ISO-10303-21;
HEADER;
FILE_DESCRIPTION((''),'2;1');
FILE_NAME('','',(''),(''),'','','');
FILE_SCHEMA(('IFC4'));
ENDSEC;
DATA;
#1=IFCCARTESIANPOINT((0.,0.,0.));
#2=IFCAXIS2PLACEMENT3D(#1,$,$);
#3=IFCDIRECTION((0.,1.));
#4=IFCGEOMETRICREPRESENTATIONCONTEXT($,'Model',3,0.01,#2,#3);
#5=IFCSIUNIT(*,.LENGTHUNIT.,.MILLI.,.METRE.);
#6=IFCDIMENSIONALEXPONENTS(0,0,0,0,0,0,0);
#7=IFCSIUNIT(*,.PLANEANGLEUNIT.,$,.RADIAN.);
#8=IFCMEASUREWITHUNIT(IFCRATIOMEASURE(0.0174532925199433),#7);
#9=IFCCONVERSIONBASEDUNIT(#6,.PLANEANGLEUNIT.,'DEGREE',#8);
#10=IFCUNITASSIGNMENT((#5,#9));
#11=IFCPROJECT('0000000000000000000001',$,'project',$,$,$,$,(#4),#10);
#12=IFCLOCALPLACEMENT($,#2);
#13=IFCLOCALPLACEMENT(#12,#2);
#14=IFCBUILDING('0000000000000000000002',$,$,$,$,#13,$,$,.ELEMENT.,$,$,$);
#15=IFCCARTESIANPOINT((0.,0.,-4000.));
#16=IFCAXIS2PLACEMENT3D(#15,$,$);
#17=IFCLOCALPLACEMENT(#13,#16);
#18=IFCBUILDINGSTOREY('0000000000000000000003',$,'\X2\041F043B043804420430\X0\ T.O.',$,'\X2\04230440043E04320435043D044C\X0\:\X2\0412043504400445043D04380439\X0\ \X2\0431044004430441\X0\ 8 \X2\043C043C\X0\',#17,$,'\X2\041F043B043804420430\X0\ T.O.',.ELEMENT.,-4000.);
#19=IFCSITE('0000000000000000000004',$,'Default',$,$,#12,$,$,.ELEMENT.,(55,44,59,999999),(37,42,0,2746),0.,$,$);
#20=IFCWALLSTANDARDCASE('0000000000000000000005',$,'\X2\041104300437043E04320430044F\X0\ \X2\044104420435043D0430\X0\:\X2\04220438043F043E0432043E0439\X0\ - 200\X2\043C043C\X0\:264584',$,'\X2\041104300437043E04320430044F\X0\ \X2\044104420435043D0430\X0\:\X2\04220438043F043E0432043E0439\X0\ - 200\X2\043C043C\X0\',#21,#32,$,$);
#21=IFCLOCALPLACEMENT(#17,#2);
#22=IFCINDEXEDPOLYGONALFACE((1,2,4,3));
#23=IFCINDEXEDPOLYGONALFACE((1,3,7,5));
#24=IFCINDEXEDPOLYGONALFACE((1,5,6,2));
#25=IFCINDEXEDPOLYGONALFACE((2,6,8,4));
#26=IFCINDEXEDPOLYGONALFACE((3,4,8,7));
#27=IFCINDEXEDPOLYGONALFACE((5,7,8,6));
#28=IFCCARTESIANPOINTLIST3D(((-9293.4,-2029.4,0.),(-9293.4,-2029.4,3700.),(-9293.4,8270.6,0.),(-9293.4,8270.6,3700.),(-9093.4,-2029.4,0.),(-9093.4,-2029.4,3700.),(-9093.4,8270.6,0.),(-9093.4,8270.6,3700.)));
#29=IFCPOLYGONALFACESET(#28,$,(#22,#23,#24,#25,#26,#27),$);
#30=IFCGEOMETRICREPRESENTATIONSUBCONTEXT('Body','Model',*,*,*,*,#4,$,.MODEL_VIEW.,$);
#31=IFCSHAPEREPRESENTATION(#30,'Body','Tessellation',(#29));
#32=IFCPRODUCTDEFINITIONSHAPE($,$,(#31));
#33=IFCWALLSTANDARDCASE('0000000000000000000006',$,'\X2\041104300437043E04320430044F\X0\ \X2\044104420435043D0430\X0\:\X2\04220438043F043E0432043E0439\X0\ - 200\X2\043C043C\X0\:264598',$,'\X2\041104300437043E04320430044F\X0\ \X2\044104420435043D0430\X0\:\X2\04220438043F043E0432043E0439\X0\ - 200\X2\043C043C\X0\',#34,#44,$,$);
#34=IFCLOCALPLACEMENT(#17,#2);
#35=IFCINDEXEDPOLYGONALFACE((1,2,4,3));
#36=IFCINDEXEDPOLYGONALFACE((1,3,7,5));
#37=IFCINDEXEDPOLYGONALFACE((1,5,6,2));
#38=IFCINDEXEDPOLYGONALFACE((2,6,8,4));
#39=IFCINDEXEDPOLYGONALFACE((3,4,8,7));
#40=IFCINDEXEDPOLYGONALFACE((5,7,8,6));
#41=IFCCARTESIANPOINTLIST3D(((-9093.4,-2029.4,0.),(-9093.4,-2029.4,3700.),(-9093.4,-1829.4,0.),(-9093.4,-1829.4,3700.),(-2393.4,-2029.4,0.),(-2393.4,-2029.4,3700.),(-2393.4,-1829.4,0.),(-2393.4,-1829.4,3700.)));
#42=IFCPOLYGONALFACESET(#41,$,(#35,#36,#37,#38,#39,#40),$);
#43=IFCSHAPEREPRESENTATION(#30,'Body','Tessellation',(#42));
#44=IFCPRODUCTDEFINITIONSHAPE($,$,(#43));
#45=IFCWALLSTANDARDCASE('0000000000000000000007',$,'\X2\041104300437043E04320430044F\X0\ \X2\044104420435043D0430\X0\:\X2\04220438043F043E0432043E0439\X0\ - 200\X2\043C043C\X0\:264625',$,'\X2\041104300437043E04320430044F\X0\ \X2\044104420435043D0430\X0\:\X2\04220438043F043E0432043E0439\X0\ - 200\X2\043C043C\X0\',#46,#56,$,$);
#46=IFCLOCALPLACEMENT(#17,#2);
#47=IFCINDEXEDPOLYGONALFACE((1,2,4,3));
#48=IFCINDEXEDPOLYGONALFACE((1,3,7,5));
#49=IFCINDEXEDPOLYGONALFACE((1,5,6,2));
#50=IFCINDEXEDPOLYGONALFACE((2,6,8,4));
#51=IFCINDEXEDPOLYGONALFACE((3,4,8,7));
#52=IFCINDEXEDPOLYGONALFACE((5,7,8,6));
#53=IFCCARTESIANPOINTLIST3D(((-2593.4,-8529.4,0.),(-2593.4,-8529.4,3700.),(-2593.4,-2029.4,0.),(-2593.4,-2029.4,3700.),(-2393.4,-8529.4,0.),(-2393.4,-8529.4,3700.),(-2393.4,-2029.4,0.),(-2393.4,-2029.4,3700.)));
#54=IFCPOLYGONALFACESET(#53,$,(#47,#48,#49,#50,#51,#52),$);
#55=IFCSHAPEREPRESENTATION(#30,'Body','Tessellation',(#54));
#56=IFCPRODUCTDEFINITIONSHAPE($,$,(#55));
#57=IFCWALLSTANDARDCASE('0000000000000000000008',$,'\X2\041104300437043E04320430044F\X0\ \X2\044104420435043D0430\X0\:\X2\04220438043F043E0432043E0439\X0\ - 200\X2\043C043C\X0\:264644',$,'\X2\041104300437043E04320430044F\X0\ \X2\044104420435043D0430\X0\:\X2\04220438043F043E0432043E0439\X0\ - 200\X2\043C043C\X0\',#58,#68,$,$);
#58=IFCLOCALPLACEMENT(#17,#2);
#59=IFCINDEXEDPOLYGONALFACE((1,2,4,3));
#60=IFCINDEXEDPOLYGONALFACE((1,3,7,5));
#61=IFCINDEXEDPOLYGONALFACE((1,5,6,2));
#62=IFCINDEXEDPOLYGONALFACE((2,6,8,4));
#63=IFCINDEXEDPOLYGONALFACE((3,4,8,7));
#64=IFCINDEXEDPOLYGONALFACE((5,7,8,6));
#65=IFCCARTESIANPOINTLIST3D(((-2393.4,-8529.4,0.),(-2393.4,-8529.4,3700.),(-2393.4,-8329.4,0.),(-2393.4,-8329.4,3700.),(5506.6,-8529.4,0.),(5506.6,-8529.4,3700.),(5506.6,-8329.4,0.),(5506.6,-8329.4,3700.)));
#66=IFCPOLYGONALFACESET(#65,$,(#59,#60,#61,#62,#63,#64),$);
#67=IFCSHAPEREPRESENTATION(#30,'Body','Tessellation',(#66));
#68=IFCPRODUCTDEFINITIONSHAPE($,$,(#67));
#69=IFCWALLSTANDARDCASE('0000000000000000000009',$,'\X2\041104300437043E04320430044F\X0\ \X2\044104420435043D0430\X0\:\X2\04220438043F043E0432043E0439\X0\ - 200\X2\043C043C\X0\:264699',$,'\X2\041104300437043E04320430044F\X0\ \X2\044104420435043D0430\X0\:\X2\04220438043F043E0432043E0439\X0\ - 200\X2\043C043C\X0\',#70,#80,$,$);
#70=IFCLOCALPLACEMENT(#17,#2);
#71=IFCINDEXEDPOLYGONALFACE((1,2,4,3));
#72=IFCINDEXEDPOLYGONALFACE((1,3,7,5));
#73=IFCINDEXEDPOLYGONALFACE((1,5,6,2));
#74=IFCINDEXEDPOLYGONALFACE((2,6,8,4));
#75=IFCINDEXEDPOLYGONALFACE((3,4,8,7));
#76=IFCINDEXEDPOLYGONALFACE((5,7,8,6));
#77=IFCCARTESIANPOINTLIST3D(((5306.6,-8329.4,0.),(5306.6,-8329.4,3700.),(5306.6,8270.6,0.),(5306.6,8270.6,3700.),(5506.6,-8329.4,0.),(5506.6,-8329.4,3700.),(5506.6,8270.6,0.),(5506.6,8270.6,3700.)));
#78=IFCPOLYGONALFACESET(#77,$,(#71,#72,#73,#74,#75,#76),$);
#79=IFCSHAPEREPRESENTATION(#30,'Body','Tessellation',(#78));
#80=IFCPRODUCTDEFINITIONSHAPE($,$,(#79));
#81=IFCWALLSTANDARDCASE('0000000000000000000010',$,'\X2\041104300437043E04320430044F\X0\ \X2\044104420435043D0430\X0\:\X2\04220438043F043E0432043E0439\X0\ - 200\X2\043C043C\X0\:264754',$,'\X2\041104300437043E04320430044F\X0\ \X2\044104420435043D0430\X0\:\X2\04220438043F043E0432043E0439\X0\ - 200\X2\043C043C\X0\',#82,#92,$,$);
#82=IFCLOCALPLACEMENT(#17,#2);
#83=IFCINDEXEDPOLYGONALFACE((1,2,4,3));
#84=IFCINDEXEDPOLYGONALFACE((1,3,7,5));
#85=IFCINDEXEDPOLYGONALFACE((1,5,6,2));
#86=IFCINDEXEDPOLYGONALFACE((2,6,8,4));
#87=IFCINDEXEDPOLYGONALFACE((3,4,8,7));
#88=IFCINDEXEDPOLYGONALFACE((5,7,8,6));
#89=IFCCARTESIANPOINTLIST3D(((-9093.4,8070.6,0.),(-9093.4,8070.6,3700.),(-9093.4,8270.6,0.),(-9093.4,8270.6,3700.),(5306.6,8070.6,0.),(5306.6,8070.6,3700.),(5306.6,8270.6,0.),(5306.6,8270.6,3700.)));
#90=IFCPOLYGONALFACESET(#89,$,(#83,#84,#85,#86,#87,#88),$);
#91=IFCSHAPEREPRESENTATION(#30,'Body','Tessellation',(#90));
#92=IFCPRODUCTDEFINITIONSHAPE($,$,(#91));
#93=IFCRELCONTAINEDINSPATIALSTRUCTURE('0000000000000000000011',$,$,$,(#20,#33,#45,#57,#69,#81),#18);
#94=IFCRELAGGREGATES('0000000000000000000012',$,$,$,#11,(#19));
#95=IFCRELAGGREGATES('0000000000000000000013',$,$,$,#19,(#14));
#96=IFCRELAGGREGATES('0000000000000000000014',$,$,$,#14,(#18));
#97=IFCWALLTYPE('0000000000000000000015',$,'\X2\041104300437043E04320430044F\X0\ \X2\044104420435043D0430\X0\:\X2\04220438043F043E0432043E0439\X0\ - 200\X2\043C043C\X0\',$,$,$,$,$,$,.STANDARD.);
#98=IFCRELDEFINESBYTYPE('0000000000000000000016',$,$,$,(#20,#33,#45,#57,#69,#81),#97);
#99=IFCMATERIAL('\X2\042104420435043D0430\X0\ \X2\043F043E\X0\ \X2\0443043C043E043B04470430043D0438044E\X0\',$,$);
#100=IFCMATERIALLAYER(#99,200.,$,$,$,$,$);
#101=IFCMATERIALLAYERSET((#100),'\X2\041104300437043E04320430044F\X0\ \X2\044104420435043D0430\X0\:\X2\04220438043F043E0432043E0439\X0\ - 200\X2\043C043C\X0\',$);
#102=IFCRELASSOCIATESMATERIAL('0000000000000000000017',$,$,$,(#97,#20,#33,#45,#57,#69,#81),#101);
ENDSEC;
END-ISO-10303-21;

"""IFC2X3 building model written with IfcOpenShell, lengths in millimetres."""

from ifc_helpers import new_model, entity, si_unit, converted_unit, direction, frame, frame_2d, origin, place, context, subcontext, project, spatial, rectangle, extrude, clip, halfspace, material, layer, layer_set, layer_usage, type_object, element, save


model = new_model("IFC2X3")

# Units and contexts
model_context = context("Model", 3, precision=0.01, world=origin(), true_north=direction((0.0, 1.0)))
body_context = subcontext(model_context, "Body", "Model", "MODEL_VIEW")
ifc_project = project(units=[si_unit("LENGTHUNIT", "METRE", prefix="MILLI"), converted_unit("PLANEANGLEUNIT", "DEGREE", entity("IfcRatioMeasure", 0.0174532925199433), si_unit("PLANEANGLEUNIT", "RADIAN"), dimensions=[0, 0, 0, 0, 0, 0, 0])], contexts=[model_context])

# Site, building, storey
site_placement = place(None, origin())
site = spatial("IfcSite", under=ifc_project, at=site_placement, Name="Default", CompositionType="ELEMENT", RefLatitude=(55, 44, 59, 999999), RefLongitude=(37, 42, 0, 2746), RefElevation=0.0)
building_placement = place(site_placement, origin())
building = spatial("IfcBuilding", under=site, at=building_placement, CompositionType="ELEMENT")
storey_placement = place(building_placement, frame((0.0, 0.0, -4000.0)))
storey = spatial("IfcBuildingStorey", under=building, at=storey_placement, Name="Плита T.O.", ObjectType="Уровень:Верхний брус 8 мм", LongName="Плита T.O.", CompositionType="ELEMENT", Elevation=-4000.0)

# Walls
ifc_material = material(Name="Стена по умолчанию")
ifc_layer = layer(ifc_material, 200.0)
ifc_layer_set = layer_set([ifc_layer], Name="Базовая стена:Типовой - 200мм")
ifc_layer_usage_1 = layer_usage(ifc_layer_set, "AXIS2", "NEGATIVE", 100.0)
wall_type = type_object("IfcWallType", Name="Базовая стена:Типовой - 200мм", PredefinedType="STANDARD", material=ifc_layer_set)
wall_1_placement = place(storey_placement, frame((-9193.4, 8270.6, 0.0), z_axis=(0.0, 0.0, 1.0), x_axis=(0.0, -1.0, 0.0)))
element("IfcWallStandardCase", 1, at=wall_1_placement, inside=storey, type_object=wall_type, material=ifc_layer_usage_1, Name="Базовая стена:Типовой - 200мм:264584", ObjectType="Базовая стена:Типовой - 200мм", context=body_context, shape_type="Clipping", body=[
    clip(extrude(rectangle(XDim=10300.0, YDim=200.0, at=frame_2d((5150.0, 0.0), x_axis=(-1.0, 0.0))), origin(), (0.0, 0.0, 1.0), 3700.0), halfspace(frame((0.0, 0.0, -600.0)), True)),
])
ifc_layer_usage_2 = layer_usage(ifc_layer_set, "AXIS2", "NEGATIVE", 100.0)
wall_2_placement = place(storey_placement, frame((-9093.4, -1929.4, 0.0)))
element("IfcWallStandardCase", 2, at=wall_2_placement, inside=storey, type_object=wall_type, material=ifc_layer_usage_2, Name="Базовая стена:Типовой - 200мм:264598", ObjectType="Базовая стена:Типовой - 200мм", context=body_context, shape_type="Clipping", body=[
    clip(extrude(rectangle(XDim=6700.0, YDim=200.0, at=frame_2d((3350.0, 0.0), x_axis=(-1.0, 0.0))), origin(), (0.0, 0.0, 1.0), 3700.0), halfspace(frame((0.0, 0.0, -600.0)), True)),
])
ifc_layer_usage_3 = layer_usage(ifc_layer_set, "AXIS2", "NEGATIVE", 100.0)
wall_3_placement = place(storey_placement, frame((-2493.4, -2029.4, 0.0), z_axis=(0.0, 0.0, 1.0), x_axis=(0.0, -1.0, 0.0)))
element("IfcWallStandardCase", 3, at=wall_3_placement, inside=storey, type_object=wall_type, material=ifc_layer_usage_3, Name="Базовая стена:Типовой - 200мм:264625", ObjectType="Базовая стена:Типовой - 200мм", context=body_context, shape_type="Clipping", body=[
    clip(extrude(rectangle(XDim=6500.0, YDim=200.0, at=frame_2d((3250.0, 0.0), x_axis=(-1.0, 0.0))), origin(), (0.0, 0.0, 1.0), 3700.0), halfspace(frame((0.0, 0.0, -600.0)), True)),
])
ifc_layer_usage_4 = layer_usage(ifc_layer_set, "AXIS2", "NEGATIVE", 100.0)
wall_4_placement = place(storey_placement, frame((-2393.4, -8429.4, 0.0)))
element("IfcWallStandardCase", 4, at=wall_4_placement, inside=storey, type_object=wall_type, material=ifc_layer_usage_4, Name="Базовая стена:Типовой - 200мм:264644", ObjectType="Базовая стена:Типовой - 200мм", context=body_context, shape_type="Clipping", body=[
    clip(extrude(rectangle(XDim=7900.0, YDim=200.0, at=frame_2d((3950.0, 0.0), x_axis=(-1.0, 0.0))), origin(), (0.0, 0.0, 1.0), 3700.0), halfspace(frame((0.0, 0.0, -600.0)), True)),
])
ifc_layer_usage_5 = layer_usage(ifc_layer_set, "AXIS2", "NEGATIVE", 100.0)
wall_5_placement = place(storey_placement, frame((5406.6, -8329.4, 0.0), z_axis=(0.0, 0.0, 1.0), x_axis=(0.0, 1.0, 0.0)))
element("IfcWallStandardCase", 5, at=wall_5_placement, inside=storey, type_object=wall_type, material=ifc_layer_usage_5, Name="Базовая стена:Типовой - 200мм:264699", ObjectType="Базовая стена:Типовой - 200мм", context=body_context, shape_type="Clipping", body=[
    clip(extrude(rectangle(XDim=16600.0, YDim=200.0, at=frame_2d((8300.0, 0.0), x_axis=(-1.0, 0.0))), origin(), (0.0, 0.0, 1.0), 3700.0), halfspace(frame((0.0, 0.0, -600.0)), True)),
])
ifc_layer_usage_6 = layer_usage(ifc_layer_set, "AXIS2", "NEGATIVE", 100.0)
wall_6_placement = place(storey_placement, frame((5306.6, 8170.6, 0.0), z_axis=(0.0, 0.0, 1.0), x_axis=(-1.0, 0.0, 0.0)))
element("IfcWallStandardCase", 6, at=wall_6_placement, inside=storey, type_object=wall_type, material=ifc_layer_usage_6, Name="Базовая стена:Типовой - 200мм:264754", ObjectType="Базовая стена:Типовой - 200мм", context=body_context, shape_type="Clipping", body=[
    clip(extrude(rectangle(XDim=14400.0, YDim=200.0, at=frame_2d((7200.0, 0.0), x_axis=(-1.0, 0.0))), origin(), (0.0, 0.0, 1.0), 3700.0), halfspace(frame((0.0, 0.0, -600.0)), True)),
])

save(model, "model.ifc")
